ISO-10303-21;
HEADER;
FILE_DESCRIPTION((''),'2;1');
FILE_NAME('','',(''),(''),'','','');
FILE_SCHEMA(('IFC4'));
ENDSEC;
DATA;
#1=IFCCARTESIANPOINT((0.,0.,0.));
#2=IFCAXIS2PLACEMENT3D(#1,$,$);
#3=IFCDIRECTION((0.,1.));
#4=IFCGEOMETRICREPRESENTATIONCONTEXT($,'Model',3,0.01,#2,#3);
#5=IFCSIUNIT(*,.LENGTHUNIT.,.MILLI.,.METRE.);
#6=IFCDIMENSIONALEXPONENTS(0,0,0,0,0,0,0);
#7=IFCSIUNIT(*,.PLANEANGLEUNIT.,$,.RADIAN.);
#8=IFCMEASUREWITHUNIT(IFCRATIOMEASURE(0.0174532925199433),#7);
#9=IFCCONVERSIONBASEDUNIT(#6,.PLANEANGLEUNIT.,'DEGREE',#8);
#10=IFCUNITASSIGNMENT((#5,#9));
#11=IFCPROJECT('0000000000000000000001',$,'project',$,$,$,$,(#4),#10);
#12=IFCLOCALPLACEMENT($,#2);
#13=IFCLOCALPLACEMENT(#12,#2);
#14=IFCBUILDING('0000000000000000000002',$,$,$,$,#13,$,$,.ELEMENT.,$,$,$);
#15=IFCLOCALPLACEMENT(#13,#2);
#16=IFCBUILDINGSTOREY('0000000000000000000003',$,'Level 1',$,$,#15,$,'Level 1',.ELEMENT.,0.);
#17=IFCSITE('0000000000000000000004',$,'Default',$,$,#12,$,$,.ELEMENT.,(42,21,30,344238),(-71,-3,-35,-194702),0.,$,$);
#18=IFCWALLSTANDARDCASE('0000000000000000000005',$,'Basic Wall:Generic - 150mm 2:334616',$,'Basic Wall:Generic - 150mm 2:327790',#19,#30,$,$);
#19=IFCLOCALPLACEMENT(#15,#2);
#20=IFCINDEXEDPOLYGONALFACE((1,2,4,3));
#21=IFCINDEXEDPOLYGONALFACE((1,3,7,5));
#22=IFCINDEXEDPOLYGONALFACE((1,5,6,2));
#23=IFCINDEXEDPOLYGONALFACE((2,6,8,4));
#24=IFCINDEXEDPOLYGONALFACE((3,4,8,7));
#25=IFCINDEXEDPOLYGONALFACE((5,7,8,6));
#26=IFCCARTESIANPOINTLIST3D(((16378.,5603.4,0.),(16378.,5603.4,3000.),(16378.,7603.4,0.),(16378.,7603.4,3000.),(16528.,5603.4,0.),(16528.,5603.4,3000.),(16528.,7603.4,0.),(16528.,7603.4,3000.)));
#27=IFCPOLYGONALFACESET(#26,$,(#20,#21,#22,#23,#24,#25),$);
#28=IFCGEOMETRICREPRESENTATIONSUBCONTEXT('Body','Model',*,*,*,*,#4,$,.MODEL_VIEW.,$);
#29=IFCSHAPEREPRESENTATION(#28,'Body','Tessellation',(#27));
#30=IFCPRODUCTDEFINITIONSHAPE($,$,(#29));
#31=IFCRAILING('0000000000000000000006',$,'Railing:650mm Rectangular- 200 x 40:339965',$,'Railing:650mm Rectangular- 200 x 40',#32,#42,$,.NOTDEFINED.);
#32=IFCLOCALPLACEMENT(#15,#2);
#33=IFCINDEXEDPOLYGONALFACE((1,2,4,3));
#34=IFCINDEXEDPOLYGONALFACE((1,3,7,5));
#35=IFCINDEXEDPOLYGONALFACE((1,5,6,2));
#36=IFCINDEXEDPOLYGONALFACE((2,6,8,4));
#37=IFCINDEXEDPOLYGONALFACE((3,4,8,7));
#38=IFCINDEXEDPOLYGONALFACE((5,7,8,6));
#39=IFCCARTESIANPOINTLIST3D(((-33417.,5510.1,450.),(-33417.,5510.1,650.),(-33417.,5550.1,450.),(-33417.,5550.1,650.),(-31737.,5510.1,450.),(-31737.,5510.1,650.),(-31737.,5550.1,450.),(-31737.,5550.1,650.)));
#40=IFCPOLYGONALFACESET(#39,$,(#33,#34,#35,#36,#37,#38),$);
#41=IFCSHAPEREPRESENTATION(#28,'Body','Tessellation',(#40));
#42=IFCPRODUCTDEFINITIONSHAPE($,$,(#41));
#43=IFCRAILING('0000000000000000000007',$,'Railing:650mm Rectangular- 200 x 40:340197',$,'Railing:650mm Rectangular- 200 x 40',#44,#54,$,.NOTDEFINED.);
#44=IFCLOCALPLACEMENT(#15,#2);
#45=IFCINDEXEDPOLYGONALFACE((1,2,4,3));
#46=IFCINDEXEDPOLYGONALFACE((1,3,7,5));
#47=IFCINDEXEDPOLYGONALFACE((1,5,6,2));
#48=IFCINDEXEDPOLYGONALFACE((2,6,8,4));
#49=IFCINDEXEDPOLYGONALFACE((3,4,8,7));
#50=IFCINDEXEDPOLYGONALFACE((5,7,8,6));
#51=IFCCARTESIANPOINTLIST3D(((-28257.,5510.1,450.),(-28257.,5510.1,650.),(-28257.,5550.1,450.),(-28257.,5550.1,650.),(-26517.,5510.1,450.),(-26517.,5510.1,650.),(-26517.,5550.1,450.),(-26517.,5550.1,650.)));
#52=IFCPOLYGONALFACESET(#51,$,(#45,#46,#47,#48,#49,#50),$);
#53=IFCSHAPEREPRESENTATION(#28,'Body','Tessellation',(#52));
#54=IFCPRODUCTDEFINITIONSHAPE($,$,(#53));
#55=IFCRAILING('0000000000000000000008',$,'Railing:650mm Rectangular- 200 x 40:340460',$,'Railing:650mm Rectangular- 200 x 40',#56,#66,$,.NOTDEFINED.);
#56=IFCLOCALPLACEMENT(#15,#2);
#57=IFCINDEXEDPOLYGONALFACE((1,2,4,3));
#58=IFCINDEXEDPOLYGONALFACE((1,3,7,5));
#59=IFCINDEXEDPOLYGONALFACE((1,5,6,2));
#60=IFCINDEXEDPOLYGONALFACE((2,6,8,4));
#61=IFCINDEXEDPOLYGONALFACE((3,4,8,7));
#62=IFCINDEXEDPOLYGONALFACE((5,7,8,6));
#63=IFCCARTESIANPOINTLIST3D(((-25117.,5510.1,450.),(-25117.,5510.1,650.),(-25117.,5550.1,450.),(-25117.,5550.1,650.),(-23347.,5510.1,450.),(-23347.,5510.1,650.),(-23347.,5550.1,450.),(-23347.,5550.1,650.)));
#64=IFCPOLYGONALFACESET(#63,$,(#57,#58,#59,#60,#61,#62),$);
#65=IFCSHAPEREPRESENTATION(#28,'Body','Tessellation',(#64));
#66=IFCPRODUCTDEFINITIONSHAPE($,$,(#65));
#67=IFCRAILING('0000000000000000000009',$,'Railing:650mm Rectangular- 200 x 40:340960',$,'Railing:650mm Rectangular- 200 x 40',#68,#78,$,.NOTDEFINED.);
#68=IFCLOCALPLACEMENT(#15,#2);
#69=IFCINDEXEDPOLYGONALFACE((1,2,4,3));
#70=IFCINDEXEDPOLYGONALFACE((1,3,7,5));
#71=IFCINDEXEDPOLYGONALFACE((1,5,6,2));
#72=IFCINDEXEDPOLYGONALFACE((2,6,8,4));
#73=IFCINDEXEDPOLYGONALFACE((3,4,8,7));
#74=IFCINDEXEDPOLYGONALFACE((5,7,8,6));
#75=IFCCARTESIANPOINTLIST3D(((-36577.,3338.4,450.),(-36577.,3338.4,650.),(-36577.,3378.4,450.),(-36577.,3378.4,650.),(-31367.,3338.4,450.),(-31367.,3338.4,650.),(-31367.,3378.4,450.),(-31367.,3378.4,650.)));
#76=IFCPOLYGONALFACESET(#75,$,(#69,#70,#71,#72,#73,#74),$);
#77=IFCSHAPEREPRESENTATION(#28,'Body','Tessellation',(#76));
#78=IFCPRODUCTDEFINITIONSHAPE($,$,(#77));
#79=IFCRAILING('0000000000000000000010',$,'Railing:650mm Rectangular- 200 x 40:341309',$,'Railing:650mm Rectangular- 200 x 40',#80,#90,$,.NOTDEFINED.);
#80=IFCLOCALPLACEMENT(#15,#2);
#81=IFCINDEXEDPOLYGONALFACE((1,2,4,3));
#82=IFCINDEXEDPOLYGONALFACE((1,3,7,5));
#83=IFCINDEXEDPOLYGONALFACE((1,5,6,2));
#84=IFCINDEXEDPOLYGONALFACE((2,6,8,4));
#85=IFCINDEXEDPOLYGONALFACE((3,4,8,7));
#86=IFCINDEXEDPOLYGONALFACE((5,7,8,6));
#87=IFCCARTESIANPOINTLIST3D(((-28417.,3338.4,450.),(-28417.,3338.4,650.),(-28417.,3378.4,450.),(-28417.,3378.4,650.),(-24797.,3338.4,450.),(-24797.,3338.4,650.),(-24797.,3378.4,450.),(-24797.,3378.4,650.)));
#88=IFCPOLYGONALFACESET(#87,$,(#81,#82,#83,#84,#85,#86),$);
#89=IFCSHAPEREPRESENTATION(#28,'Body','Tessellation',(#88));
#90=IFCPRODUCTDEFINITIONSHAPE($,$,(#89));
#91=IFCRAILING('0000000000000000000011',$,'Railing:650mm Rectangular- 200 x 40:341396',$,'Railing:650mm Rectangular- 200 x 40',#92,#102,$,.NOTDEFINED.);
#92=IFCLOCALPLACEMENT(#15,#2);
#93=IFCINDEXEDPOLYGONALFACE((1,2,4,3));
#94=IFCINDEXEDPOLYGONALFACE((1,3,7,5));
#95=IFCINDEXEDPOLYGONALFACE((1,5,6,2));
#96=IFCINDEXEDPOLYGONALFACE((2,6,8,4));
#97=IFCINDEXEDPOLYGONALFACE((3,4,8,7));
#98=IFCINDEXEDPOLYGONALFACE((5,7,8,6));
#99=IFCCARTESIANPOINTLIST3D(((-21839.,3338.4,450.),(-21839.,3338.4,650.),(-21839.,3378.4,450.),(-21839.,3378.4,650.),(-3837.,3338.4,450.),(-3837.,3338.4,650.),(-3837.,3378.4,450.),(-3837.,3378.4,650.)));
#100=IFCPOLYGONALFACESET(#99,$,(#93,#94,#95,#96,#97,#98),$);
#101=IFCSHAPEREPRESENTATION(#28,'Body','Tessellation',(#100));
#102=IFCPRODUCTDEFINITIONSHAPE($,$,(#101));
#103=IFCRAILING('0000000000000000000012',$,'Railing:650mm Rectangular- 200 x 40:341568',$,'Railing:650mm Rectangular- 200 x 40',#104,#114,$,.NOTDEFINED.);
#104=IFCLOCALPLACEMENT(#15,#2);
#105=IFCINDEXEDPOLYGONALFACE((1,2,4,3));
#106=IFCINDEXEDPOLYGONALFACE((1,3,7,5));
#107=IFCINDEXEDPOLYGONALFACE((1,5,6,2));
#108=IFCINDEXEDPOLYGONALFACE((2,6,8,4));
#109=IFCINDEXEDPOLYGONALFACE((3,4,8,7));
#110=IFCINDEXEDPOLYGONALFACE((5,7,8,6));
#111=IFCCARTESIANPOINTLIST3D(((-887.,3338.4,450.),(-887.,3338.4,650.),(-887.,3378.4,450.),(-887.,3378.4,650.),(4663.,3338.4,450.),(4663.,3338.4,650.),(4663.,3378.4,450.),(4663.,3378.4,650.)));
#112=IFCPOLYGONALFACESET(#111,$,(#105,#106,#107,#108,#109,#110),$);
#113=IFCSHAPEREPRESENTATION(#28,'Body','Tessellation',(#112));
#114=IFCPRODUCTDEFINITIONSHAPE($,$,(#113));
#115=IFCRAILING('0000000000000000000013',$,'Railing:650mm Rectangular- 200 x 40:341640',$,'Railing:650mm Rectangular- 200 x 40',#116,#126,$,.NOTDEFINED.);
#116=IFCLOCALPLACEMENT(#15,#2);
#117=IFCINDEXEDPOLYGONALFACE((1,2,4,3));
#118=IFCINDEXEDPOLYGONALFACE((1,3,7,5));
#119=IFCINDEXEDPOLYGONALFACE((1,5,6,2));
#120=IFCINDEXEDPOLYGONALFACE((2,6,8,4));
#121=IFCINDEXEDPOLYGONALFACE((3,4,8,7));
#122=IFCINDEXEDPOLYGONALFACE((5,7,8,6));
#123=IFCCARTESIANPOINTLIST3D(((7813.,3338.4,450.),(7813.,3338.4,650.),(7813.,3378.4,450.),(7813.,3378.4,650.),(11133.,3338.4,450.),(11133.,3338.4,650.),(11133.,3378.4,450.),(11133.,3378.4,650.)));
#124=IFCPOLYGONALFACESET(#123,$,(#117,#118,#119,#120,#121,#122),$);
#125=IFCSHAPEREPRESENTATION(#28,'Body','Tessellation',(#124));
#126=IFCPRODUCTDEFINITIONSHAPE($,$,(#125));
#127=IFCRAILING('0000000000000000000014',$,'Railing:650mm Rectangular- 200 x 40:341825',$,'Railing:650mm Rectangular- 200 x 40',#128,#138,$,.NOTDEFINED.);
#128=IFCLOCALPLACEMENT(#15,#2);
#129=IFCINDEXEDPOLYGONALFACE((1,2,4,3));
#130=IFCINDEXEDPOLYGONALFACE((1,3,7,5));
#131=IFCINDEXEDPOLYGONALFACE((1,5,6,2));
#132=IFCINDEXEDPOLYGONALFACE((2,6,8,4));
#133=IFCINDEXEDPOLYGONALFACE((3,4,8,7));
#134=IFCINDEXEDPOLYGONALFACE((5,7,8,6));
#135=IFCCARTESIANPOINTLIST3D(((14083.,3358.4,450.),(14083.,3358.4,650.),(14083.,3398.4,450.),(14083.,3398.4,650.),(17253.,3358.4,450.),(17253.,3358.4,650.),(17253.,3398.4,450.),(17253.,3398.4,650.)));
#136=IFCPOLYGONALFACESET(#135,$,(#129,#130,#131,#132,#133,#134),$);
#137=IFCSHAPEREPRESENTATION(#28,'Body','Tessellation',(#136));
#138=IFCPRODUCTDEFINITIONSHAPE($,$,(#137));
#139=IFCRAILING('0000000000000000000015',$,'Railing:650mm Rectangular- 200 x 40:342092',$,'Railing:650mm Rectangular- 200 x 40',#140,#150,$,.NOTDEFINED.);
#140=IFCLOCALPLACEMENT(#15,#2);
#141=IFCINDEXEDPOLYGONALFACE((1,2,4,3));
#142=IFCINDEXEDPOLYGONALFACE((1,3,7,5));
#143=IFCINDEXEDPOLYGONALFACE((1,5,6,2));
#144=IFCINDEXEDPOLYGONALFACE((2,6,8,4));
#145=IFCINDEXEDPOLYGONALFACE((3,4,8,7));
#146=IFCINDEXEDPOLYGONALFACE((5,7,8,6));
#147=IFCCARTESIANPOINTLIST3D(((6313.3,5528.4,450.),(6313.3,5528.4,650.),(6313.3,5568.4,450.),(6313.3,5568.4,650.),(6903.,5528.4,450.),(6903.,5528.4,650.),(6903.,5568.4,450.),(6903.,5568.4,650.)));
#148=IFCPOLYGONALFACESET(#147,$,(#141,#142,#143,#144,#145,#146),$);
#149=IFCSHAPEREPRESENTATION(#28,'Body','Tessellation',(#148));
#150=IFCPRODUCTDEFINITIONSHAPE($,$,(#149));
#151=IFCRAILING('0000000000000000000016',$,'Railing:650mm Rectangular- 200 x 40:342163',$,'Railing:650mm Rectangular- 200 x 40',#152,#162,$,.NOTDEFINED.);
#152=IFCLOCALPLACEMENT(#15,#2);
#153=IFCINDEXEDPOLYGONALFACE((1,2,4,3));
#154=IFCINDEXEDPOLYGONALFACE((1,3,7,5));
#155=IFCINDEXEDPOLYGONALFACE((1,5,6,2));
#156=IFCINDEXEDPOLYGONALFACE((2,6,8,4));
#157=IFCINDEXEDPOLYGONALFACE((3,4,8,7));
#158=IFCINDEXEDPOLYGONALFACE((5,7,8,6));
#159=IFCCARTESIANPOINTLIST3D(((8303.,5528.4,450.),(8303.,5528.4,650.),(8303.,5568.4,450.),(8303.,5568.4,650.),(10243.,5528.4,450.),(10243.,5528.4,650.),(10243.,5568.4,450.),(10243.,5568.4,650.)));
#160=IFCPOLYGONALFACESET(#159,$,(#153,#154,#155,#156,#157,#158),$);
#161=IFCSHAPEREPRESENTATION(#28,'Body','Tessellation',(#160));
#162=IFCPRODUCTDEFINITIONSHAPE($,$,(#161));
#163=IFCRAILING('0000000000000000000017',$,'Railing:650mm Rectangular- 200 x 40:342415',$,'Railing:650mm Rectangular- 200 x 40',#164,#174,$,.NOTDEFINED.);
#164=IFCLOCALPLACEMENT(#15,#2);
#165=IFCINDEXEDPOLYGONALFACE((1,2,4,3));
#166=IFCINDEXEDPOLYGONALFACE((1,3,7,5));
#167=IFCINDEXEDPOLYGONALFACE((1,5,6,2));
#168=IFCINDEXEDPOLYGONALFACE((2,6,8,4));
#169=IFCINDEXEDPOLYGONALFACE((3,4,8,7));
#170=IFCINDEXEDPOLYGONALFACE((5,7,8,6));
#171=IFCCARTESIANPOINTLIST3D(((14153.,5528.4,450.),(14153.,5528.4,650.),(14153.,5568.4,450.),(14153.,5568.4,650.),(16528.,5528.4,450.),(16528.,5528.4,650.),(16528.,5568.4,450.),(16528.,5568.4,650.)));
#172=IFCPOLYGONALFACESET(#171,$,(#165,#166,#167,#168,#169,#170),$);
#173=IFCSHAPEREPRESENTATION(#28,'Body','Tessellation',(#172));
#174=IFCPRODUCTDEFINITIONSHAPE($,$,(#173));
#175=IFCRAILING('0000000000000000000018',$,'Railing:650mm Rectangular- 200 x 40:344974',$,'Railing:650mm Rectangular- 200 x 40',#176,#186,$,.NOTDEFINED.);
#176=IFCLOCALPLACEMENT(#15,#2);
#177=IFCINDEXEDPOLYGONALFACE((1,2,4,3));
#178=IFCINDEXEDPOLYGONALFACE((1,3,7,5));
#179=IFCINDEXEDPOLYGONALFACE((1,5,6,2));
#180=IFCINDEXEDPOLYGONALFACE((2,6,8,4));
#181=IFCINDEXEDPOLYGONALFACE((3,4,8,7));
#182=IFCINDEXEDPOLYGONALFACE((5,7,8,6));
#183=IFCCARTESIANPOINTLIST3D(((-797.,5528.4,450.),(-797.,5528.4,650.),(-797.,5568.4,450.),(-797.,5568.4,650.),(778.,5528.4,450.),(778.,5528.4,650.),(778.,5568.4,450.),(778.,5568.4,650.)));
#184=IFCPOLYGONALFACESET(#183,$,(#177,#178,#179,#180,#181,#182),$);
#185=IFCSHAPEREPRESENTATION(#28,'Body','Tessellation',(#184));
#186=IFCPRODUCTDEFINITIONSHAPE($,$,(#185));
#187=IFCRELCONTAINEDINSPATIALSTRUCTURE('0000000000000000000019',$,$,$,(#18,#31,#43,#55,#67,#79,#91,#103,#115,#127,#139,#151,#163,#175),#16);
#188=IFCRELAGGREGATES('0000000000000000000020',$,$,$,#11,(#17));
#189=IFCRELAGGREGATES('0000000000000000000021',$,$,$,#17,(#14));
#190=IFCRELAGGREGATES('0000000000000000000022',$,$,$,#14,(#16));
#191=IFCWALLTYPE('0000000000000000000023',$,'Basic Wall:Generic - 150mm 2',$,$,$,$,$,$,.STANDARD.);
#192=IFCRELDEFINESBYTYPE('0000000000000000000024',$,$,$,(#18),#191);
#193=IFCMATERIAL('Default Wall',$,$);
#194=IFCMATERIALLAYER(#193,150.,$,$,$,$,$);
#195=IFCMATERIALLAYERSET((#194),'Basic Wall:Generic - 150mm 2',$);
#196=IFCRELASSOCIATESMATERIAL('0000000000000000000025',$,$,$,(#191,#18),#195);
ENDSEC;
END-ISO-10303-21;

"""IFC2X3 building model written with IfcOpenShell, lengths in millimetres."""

from ifc_helpers import new_model, entity, si_unit, converted_unit, direction, frame, frame_2d, origin, origin_2d_with_axis, place, context, subcontext, project, spatial, rectangle, extrude, material, layer, layer_set, layer_usage, type_object, element, save


model = new_model("IFC2X3")

# Units and contexts
model_context = context("Model", 3, precision=0.01, world=origin(), true_north=direction((0.0, 1.0)))
body_context = subcontext(model_context, "Body", "Model", "MODEL_VIEW")
ifc_project = project(units=[si_unit("LENGTHUNIT", "METRE", prefix="MILLI"), converted_unit("PLANEANGLEUNIT", "DEGREE", entity("IfcRatioMeasure", 0.0174532925199433), si_unit("PLANEANGLEUNIT", "RADIAN"), dimensions=[0, 0, 0, 0, 0, 0, 0])], contexts=[model_context])

# Site, building, storey
site_placement = place(None, origin())
site = spatial("IfcSite", under=ifc_project, at=site_placement, Name="Default", CompositionType="ELEMENT", RefLatitude=(42, 21, 30, 344238), RefLongitude=(-71, -3, -35, -194702), RefElevation=0.0)
building_placement = place(site_placement, origin())
building = spatial("IfcBuilding", under=site, at=building_placement, CompositionType="ELEMENT")
storey_placement = place(building_placement, origin())
storey = spatial("IfcBuildingStorey", under=building, at=storey_placement, Name="Level 1", LongName="Level 1", CompositionType="ELEMENT", Elevation=0.0)

# Shared definitions
ifc_material_1 = material(Name="Default Wall")
ifc_layer = layer(ifc_material_1, 150.0)
ifc_layer_set = layer_set([ifc_layer], Name="Basic Wall:Generic - 150mm 2")
wall_type = type_object("IfcWallType", Name="Basic Wall:Generic - 150mm 2", PredefinedType="STANDARD", material=ifc_layer_set)

# Wall
ifc_layer_usage_1 = layer_usage(ifc_layer_set, "AXIS2", "NEGATIVE", 75.0)
wall_1_placement = place(storey_placement, frame((16453.0, 7603.4, 0.0), z_axis=(0.0, 0.0, 1.0), x_axis=(0.0, -1.0, 0.0)))
element("IfcWallStandardCase", 1, at=wall_1_placement, inside=storey, type_object=wall_type, material=ifc_layer_usage_1, Name="Basic Wall:Generic - 150mm 2:334616", ObjectType="Basic Wall:Generic - 150mm 2:327790", context=body_context, shape_type="SweptSolid", body=[
    extrude(rectangle(XDim=2000.0, YDim=150.0, at=frame_2d((1000.0, 0.0), x_axis=(-1.0, 0.0))), origin(), (0.0, 0.0, 1.0), 3000.0),
])

# Railings
railing_1_placement = place(storey_placement, origin())
element("IfcRailing", 2, at=railing_1_placement, inside=storey, Name="Railing:650mm Rectangular- 200 x 40:339965", ObjectType="Railing:650mm Rectangular- 200 x 40", PredefinedType="NOTDEFINED", context=body_context, shape_type="SweptSolid", body=[
    extrude(rectangle(XDim=1680.0, YDim=40.0, at=frame_2d((0.0, 0.0), x_axis=(1.0, 0.0))), frame((-32577.0, 5530.1, 450.0)), (0.0, 0.0, 1.0), 200.0),
])
railing_2_placement = place(storey_placement, origin())
element("IfcRailing", 3, at=railing_2_placement, inside=storey, Name="Railing:650mm Rectangular- 200 x 40:340197", ObjectType="Railing:650mm Rectangular- 200 x 40", PredefinedType="NOTDEFINED", context=body_context, shape_type="SweptSolid", body=[
    extrude(rectangle(XDim=1740.0, YDim=40.0, at=frame_2d((0.0, 0.0), x_axis=(1.0, 0.0))), frame((-27387.0, 5530.1, 450.0)), (0.0, 0.0, 1.0), 200.0),
])
railing_3_placement = place(storey_placement, origin())
element("IfcRailing", 4, at=railing_3_placement, inside=storey, Name="Railing:650mm Rectangular- 200 x 40:340460", ObjectType="Railing:650mm Rectangular- 200 x 40", PredefinedType="NOTDEFINED", context=body_context, shape_type="SweptSolid", body=[
    extrude(rectangle(XDim=1770.0, YDim=40.0, at=frame_2d((0.0, 0.0), x_axis=(1.0, 0.0))), frame((-24232.0, 5530.1, 450.0)), (0.0, 0.0, 1.0), 200.0),
])
railing_4_placement = place(storey_placement, origin())
element("IfcRailing", 5, at=railing_4_placement, inside=storey, Name="Railing:650mm Rectangular- 200 x 40:340960", ObjectType="Railing:650mm Rectangular- 200 x 40", PredefinedType="NOTDEFINED", context=body_context, shape_type="SweptSolid", body=[
    extrude(rectangle(XDim=5210.0, YDim=40.0, at=frame_2d((0.0, 0.0), x_axis=(1.0, 0.0))), frame((-33972.0, 3358.4, 450.0), z_axis=(0.0, 0.0, 1.0), x_axis=(-1.0, 0.0, 0.0)), (0.0, 0.0, 1.0), 200.0),
])
railing_5_placement = place(storey_placement, origin())
element("IfcRailing", 6, at=railing_5_placement, inside=storey, Name="Railing:650mm Rectangular- 200 x 40:341309", ObjectType="Railing:650mm Rectangular- 200 x 40", PredefinedType="NOTDEFINED", context=body_context, shape_type="SweptSolid", body=[
    extrude(rectangle(XDim=3620.0, YDim=40.0, at=frame_2d((0.0, 0.0), x_axis=(1.0, 0.0))), frame((-26607.0, 3358.4, 450.0), z_axis=(0.0, 0.0, 1.0), x_axis=(-1.0, 0.0, 0.0)), (0.0, 0.0, 1.0), 200.0),
])
railing_6_placement = place(storey_placement, origin())
element("IfcRailing", 7, at=railing_6_placement, inside=storey, Name="Railing:650mm Rectangular- 200 x 40:341396", ObjectType="Railing:650mm Rectangular- 200 x 40", PredefinedType="NOTDEFINED", context=body_context, shape_type="SweptSolid", body=[
    extrude(rectangle(XDim=18002.0, YDim=40.0, at=frame_2d((0.0, 0.0), x_axis=(1.0, 0.0))), frame((-12838.0, 3358.4, 450.0), z_axis=(0.0, 0.0, 1.0), x_axis=(-1.0, 0.0, 0.0)), (0.0, 0.0, 1.0), 200.0),
])
railing_7_placement = place(storey_placement, origin())
element("IfcRailing", 8, at=railing_7_placement, inside=storey, Name="Railing:650mm Rectangular- 200 x 40:341568", ObjectType="Railing:650mm Rectangular- 200 x 40", PredefinedType="NOTDEFINED", context=body_context, shape_type="SweptSolid", body=[
    extrude(rectangle(XDim=5550.0, YDim=40.0, at=origin_2d_with_axis()), frame((1888.0, 3358.4, 450.0), z_axis=(0.0, 0.0, 1.0), x_axis=(-1.0, 0.0, 0.0)), (0.0, 0.0, 1.0), 200.0),
])
railing_8_placement = place(storey_placement, origin())
element("IfcRailing", 9, at=railing_8_placement, inside=storey, Name="Railing:650mm Rectangular- 200 x 40:341640", ObjectType="Railing:650mm Rectangular- 200 x 40", PredefinedType="NOTDEFINED", context=body_context, shape_type="SweptSolid", body=[
    extrude(rectangle(XDim=3320.0, YDim=40.0, at=frame_2d((0.0, 0.0), x_axis=(1.0, 0.0))), frame((9473.0, 3358.4, 450.0), z_axis=(0.0, 0.0, 1.0), x_axis=(-1.0, 0.0, 0.0)), (0.0, 0.0, 1.0), 200.0),
])
railing_9_placement = place(storey_placement, origin())
element("IfcRailing", 10, at=railing_9_placement, inside=storey, Name="Railing:650mm Rectangular- 200 x 40:341825", ObjectType="Railing:650mm Rectangular- 200 x 40", PredefinedType="NOTDEFINED", context=body_context, shape_type="SweptSolid", body=[
    extrude(rectangle(XDim=3170.0, YDim=40.0, at=frame_2d((0.0, 0.0), x_axis=(1.0, 0.0))), frame((15668.0, 3378.4, 450.0), z_axis=(0.0, 0.0, 1.0), x_axis=(-1.0, 0.0, 0.0)), (0.0, 0.0, 1.0), 200.0),
])
railing_10_placement = place(storey_placement, origin())
element("IfcRailing", 11, at=railing_10_placement, inside=storey, Name="Railing:650mm Rectangular- 200 x 40:342092", ObjectType="Railing:650mm Rectangular- 200 x 40", PredefinedType="NOTDEFINED", context=body_context, shape_type="SweptSolid", body=[
    extrude(rectangle(XDim=589.7, YDim=40.0, at=frame_2d((0.0, 0.0), x_axis=(1.0, 0.0))), frame((6608.1, 5548.4, 450.0)), (0.0, 0.0, 1.0), 200.0),
])
railing_11_placement = place(storey_placement, origin())
element("IfcRailing", 12, at=railing_11_placement, inside=storey, Name="Railing:650mm Rectangular- 200 x 40:342163", ObjectType="Railing:650mm Rectangular- 200 x 40", PredefinedType="NOTDEFINED", context=body_context, shape_type="SweptSolid", body=[
    extrude(rectangle(XDim=1940.0, YDim=40.0, at=origin_2d_with_axis()), frame((9273.0, 5548.4, 450.0)), (0.0, 0.0, 1.0), 200.0),
])
railing_12_placement = place(storey_placement, origin())
element("IfcRailing", 13, at=railing_12_placement, inside=storey, Name="Railing:650mm Rectangular- 200 x 40:342415", ObjectType="Railing:650mm Rectangular- 200 x 40", PredefinedType="NOTDEFINED", context=body_context, shape_type="SweptSolid", body=[
    extrude(rectangle(XDim=2375.0, YDim=40.0, at=frame_2d((0.0, 0.0), x_axis=(1.0, 0.0))), frame((15340.5, 5548.4, 450.0)), (0.0, 0.0, 1.0), 200.0),
])
railing_13_placement = place(storey_placement, origin())
element("IfcRailing", 14, at=railing_13_placement, inside=storey, Name="Railing:650mm Rectangular- 200 x 40:344974", ObjectType="Railing:650mm Rectangular- 200 x 40", PredefinedType="NOTDEFINED", context=body_context, shape_type="SweptSolid", body=[
    extrude(rectangle(XDim=1575.0, YDim=40.0, at=frame_2d((0.0, 0.0), x_axis=(1.0, 0.0))), frame((-9.5, 5548.4, 450.0)), (0.0, 0.0, 1.0), 200.0),
])

save(model, "model.ifc")
